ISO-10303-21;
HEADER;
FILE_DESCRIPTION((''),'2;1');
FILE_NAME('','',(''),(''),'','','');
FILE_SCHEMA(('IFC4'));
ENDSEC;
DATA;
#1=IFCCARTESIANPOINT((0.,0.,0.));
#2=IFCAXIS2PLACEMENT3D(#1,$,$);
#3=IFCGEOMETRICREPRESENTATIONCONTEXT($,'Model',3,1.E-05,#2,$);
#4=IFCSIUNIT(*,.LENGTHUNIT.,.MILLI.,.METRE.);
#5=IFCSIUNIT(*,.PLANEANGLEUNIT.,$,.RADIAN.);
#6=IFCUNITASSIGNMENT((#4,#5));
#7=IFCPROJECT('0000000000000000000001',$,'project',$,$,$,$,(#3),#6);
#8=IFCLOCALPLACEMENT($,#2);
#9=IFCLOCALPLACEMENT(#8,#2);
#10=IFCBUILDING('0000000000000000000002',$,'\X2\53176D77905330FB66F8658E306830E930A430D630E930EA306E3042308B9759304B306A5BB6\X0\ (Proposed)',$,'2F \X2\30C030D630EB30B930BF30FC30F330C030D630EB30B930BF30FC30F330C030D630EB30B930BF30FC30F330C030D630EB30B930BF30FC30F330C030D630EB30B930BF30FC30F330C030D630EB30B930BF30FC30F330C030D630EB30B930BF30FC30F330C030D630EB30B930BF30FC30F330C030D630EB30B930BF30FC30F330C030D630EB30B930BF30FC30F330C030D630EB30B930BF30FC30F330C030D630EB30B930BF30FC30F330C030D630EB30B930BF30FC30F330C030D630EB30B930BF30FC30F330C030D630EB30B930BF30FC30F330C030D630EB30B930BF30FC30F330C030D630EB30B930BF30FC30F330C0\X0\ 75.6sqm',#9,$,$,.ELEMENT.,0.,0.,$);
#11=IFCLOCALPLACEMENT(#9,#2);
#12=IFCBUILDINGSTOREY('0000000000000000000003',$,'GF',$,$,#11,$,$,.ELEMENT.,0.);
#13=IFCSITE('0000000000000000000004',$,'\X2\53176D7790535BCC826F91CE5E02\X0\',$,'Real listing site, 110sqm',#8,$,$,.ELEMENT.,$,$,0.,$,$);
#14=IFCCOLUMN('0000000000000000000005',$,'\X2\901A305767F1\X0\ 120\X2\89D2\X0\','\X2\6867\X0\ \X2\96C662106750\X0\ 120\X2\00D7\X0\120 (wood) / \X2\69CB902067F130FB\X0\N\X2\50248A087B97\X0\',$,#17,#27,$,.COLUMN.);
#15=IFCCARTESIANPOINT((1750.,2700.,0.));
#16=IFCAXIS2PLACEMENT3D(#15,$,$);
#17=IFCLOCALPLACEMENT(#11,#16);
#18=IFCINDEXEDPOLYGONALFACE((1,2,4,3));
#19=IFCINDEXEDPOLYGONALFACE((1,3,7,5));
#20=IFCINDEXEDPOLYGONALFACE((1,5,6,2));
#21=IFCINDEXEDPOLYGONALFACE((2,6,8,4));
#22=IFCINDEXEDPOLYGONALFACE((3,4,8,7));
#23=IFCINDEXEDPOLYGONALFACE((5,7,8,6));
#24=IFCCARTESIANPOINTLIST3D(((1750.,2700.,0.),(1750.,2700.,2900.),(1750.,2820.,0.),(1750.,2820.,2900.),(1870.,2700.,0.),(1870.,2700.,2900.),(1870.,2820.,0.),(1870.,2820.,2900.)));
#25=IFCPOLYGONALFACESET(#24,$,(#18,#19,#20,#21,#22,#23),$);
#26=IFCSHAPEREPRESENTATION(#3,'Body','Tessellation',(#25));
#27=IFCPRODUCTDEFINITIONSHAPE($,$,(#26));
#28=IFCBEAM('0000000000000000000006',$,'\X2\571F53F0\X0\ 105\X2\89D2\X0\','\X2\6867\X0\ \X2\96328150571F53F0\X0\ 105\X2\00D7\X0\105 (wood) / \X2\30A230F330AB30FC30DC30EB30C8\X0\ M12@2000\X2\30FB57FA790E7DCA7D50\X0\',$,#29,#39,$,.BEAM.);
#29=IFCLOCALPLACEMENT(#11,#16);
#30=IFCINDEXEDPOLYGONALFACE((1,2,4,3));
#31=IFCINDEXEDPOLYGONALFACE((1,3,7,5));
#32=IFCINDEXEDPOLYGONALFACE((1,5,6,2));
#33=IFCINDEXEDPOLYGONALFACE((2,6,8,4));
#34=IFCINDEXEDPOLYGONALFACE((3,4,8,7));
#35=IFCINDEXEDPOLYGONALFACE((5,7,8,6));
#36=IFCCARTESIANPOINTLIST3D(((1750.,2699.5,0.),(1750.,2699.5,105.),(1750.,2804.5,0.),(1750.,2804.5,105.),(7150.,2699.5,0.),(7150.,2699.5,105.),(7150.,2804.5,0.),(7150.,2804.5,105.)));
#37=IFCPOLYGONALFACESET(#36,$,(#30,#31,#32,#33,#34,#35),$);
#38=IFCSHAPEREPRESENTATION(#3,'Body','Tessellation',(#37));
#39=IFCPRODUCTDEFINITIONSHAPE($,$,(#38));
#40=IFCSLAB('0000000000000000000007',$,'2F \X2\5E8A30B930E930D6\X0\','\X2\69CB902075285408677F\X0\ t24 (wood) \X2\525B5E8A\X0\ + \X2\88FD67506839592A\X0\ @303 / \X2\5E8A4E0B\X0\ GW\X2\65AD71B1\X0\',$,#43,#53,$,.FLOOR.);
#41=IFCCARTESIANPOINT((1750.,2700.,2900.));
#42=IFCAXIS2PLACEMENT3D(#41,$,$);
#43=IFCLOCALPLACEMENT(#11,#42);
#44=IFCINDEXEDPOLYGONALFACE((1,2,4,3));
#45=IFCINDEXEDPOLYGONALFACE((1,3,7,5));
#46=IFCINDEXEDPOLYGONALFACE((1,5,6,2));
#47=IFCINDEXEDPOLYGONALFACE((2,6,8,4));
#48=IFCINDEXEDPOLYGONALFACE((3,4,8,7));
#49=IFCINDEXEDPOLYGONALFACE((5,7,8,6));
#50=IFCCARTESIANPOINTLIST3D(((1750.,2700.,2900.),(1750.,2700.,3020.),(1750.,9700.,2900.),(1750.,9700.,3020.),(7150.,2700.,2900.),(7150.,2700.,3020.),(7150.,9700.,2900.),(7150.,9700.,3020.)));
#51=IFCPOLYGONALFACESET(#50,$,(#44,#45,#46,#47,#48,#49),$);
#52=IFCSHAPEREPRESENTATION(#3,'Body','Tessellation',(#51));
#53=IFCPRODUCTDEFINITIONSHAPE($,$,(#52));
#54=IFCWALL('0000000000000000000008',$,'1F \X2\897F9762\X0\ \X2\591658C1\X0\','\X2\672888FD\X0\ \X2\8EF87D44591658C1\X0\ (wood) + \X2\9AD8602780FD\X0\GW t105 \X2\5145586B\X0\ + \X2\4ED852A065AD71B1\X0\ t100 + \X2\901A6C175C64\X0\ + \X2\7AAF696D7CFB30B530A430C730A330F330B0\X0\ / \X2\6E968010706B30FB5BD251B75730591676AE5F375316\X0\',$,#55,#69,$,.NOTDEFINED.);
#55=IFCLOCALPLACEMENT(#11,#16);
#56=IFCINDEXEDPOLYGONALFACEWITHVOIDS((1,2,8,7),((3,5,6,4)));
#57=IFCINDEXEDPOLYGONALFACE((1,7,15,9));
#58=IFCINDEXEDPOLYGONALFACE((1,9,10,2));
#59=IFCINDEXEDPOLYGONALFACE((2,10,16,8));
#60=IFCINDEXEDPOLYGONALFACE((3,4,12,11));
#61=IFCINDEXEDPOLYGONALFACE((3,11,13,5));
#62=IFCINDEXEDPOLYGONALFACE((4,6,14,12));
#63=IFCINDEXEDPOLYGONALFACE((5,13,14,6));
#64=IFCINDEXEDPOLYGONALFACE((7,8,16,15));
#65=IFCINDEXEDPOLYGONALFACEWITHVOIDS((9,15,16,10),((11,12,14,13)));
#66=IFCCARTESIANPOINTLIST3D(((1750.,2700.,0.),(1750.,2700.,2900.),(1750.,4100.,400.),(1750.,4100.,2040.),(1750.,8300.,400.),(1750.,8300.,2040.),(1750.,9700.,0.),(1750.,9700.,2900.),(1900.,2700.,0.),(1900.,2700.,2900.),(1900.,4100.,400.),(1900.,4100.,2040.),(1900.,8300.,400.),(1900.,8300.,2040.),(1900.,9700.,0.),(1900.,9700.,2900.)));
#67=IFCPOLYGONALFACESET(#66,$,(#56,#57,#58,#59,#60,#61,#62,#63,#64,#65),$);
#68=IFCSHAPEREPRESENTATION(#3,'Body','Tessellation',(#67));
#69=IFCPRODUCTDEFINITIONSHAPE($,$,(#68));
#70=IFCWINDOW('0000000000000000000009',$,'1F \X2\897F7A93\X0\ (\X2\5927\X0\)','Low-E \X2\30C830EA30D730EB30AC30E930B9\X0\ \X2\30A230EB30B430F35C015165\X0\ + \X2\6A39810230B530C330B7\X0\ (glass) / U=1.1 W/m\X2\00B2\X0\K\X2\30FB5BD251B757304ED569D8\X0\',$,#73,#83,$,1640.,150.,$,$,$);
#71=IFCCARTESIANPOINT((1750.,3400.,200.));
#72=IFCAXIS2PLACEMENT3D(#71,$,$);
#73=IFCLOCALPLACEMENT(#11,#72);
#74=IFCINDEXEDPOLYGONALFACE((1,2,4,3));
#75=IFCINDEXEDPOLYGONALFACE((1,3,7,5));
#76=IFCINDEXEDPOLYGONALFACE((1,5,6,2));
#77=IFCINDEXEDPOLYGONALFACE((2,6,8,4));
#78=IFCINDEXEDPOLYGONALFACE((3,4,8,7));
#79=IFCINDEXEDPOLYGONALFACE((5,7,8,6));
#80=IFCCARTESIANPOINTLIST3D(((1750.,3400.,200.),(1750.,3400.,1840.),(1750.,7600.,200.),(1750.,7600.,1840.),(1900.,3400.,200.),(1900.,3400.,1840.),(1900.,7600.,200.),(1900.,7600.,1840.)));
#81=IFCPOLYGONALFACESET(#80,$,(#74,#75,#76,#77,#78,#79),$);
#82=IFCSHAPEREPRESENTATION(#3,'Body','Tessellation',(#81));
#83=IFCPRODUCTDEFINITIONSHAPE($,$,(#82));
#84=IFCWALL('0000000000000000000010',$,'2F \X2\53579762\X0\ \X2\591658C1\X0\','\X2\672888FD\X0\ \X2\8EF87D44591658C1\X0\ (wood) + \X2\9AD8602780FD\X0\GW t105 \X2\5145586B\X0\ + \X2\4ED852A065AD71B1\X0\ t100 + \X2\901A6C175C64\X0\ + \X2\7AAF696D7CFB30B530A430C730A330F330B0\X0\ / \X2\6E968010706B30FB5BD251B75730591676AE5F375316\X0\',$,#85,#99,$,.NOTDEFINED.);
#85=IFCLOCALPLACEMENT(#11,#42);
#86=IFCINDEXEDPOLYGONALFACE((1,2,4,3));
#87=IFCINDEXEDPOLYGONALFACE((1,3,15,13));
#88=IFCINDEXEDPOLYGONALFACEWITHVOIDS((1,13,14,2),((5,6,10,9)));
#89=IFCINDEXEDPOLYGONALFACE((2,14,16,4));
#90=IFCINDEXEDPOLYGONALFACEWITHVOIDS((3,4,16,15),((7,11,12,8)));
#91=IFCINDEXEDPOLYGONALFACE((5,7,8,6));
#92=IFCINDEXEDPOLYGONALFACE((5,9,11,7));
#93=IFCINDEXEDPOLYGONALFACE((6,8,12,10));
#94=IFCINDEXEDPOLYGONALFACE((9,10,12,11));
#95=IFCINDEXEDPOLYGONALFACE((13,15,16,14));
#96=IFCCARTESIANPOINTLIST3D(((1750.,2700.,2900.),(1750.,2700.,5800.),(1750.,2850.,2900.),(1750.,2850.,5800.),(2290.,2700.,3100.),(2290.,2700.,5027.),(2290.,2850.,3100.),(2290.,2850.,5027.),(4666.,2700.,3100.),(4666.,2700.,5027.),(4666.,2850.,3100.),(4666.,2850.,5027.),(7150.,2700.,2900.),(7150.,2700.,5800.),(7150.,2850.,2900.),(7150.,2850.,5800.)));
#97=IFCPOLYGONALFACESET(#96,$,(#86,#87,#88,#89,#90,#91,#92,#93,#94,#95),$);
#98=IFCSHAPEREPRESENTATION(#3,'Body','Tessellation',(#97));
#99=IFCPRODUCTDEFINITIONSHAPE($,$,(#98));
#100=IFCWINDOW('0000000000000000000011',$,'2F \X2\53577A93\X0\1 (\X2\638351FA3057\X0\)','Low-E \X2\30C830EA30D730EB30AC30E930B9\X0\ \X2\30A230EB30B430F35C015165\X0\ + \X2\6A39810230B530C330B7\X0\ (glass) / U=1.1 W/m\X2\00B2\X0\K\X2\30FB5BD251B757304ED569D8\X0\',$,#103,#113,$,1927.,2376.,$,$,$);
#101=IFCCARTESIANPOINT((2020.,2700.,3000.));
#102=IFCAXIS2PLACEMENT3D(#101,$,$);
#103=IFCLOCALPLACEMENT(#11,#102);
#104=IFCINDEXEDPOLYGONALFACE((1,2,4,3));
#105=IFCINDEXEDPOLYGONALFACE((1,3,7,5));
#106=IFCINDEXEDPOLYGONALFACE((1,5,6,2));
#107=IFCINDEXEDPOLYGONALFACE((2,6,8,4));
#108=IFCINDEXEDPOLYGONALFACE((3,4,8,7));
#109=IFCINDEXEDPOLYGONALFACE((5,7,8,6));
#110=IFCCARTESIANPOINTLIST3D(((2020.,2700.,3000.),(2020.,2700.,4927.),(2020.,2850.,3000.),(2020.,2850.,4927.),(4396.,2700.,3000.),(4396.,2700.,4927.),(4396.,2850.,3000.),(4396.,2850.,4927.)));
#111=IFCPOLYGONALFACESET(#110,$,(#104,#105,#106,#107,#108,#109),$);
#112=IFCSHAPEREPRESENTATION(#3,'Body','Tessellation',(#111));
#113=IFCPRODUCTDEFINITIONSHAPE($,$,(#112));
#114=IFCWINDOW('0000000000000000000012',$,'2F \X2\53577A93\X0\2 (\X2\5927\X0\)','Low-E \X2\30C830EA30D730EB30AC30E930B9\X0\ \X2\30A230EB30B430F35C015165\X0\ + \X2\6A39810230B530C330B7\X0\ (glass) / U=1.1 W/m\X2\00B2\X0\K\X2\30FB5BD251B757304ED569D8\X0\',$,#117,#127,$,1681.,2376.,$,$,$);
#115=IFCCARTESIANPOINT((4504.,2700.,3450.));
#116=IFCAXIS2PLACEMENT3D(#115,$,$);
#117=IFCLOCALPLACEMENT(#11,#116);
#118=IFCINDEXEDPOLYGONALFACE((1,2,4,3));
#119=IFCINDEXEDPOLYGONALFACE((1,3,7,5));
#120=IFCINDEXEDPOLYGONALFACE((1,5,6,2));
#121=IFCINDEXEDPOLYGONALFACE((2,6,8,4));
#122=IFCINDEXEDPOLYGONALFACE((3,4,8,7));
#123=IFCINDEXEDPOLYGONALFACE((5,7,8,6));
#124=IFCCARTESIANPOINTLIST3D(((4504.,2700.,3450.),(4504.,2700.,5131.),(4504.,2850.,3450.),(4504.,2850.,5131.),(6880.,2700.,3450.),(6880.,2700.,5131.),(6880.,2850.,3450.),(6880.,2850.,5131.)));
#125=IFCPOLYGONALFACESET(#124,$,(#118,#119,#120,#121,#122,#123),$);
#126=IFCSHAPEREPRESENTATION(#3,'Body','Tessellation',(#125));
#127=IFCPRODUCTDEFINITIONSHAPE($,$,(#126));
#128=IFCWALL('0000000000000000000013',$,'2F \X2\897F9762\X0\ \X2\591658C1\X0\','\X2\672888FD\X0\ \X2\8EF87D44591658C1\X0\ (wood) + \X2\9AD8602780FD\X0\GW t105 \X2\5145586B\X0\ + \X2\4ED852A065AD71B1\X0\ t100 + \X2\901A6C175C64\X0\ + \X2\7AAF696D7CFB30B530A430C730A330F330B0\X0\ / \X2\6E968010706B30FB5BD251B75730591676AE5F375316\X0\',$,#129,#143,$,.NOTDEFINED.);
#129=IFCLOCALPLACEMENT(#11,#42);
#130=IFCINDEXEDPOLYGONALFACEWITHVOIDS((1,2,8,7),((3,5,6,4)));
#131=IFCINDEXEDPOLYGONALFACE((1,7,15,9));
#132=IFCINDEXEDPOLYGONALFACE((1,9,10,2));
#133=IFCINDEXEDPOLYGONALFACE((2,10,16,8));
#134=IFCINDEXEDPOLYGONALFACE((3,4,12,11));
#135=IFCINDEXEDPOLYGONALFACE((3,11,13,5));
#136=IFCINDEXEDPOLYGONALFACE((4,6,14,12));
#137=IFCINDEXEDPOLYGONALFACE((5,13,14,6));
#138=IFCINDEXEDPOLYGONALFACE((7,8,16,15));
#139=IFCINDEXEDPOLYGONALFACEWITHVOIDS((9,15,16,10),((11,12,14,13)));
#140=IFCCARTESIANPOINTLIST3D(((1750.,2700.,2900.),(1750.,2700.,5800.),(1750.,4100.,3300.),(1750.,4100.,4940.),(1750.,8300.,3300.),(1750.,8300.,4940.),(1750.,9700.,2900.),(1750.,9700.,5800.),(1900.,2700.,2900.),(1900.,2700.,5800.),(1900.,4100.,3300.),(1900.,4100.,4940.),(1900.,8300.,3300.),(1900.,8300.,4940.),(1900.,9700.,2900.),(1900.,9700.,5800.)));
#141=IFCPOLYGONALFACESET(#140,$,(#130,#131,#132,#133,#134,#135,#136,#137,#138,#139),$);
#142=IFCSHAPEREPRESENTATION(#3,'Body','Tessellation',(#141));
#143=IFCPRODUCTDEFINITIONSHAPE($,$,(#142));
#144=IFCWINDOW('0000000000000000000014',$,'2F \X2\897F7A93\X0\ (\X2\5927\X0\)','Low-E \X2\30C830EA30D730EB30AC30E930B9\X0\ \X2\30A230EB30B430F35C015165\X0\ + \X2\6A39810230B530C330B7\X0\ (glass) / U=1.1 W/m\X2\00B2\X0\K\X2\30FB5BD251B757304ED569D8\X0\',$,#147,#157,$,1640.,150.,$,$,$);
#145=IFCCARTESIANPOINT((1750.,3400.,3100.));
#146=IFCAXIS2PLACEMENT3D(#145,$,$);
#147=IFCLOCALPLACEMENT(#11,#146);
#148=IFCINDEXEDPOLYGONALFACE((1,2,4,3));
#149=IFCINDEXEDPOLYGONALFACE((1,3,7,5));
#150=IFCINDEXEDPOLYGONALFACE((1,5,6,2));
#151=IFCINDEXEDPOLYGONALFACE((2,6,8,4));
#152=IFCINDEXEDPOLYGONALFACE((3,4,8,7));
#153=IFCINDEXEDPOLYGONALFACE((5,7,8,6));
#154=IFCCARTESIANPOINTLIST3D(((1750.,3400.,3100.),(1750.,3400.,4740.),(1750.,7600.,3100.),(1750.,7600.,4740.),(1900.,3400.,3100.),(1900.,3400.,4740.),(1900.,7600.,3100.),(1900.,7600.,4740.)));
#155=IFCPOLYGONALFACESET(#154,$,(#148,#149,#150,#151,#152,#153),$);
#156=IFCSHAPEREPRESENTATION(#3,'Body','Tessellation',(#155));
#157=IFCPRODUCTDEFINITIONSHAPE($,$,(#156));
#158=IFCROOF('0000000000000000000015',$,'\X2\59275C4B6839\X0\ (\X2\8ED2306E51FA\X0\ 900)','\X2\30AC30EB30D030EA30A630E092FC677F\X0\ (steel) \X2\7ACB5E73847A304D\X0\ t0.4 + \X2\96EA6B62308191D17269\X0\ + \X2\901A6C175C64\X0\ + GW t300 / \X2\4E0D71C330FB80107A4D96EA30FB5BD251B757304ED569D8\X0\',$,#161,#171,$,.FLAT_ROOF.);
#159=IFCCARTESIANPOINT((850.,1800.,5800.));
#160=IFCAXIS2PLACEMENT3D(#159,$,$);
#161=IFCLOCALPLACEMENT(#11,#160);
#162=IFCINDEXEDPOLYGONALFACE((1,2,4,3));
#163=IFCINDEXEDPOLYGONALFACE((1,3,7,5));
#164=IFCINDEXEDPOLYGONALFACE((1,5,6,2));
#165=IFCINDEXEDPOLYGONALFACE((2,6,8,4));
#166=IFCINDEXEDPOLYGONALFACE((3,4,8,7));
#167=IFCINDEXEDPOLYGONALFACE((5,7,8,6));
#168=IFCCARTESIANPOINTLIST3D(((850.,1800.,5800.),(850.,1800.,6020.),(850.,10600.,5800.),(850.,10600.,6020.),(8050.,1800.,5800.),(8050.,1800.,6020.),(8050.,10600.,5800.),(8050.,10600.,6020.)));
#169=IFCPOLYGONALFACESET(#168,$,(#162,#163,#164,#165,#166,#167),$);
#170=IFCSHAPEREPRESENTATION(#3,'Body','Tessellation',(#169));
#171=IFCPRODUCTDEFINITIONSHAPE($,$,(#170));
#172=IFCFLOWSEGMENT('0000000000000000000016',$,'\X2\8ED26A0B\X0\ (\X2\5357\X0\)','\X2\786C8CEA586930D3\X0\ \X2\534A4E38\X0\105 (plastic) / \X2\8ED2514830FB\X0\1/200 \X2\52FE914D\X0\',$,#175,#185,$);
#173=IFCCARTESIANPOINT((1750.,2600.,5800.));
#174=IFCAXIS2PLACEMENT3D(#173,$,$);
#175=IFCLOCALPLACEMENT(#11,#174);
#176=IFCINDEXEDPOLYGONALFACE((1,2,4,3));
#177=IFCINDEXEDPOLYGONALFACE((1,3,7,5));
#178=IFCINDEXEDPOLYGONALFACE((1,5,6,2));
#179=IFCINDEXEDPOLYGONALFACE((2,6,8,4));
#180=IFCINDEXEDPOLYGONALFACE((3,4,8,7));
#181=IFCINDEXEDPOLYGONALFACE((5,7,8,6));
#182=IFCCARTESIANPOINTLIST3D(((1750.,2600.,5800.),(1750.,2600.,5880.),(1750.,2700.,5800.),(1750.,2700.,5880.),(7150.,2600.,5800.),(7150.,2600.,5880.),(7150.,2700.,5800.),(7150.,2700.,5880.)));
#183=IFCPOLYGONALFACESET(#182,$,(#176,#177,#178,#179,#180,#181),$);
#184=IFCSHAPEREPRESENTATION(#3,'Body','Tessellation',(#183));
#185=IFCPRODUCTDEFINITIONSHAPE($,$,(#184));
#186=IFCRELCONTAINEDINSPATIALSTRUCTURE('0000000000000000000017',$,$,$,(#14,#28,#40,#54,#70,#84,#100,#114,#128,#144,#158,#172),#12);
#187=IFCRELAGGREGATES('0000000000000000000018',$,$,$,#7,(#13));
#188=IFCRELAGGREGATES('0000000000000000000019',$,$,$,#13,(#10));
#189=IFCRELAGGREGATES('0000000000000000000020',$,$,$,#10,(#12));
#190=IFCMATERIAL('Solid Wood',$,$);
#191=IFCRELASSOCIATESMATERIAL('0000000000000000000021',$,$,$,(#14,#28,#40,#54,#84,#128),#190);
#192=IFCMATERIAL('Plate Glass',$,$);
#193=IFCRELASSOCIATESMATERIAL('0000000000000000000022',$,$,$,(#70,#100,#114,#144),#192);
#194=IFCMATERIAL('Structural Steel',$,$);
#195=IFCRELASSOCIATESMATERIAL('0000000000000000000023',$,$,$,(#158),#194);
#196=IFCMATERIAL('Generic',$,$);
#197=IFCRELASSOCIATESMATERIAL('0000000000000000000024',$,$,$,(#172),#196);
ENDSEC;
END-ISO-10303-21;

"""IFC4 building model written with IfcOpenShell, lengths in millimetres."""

from ifc_helpers import new_model, si_unit, frame, frame_2d, origin, place, context, project, spatial, rectangle, extrude, material, element, fill, save


model = new_model("IFC4")

# Units and contexts
model_context = context("Model", 3, precision=1e-05, world=origin())
ifc_project = project(units=[si_unit("LENGTHUNIT", "METRE", prefix="MILLI"), si_unit("PLANEANGLEUNIT", "RADIAN")], contexts=[model_context])

# Site, building, storey
site_placement = place(None, origin())
site = spatial("IfcSite", under=ifc_project, at=site_placement, Name="北海道富良野市", ObjectType="Real listing site, 110sqm", CompositionType="ELEMENT", RefElevation=0.0)
building_placement = place(site_placement, origin())
building = spatial("IfcBuilding", under=site, at=building_placement, Name="北海道・書斎とライブラリのある静かな家 (Proposed)", ObjectType="2F ダブルスターンダブルスターンダブルスターンダブルスターンダブルスターンダブルスターンダブルスターンダブルスターンダブルスターンダブルスターンダブルスターンダブルスターンダブルスターンダブルスターンダブルスターンダブルスターンダブルスターンダ 75.6sqm", CompositionType="ELEMENT", ElevationOfRefHeight=0.0, ElevationOfTerrain=0.0)
storey_placement = place(building_placement, origin())
storey = spatial("IfcBuildingStorey", under=building, at=storey_placement, Name="GF", CompositionType="ELEMENT", Elevation=0.0)

# Column
ifc_material_1 = material(Name="Solid Wood")
column_placement = place(storey_placement, frame((1750.0, 2700.0, 0.0)))
element("IfcColumn", 1, at=column_placement, inside=storey, material=ifc_material_1, Name="通し柱 120角", Description="桧 集成材 120×120 (wood) / 構造柱・N値計算", PredefinedType="COLUMN", context=model_context, shape_type="SweptSolid", body=[
    extrude(rectangle(XDim=120.0, YDim=120.0, at=frame_2d((60.0, 60.0))), frame((1750.0, 2700.0, 0.0)), (0.0, 0.0, 1.0), 2900.0),
])

# Beam
beam_1_placement = place(storey_placement, frame((1750.0, 2700.0, 0.0)))
element("IfcBeam", 2, at=beam_1_placement, inside=storey, material=ifc_material_1, Name="土台 105角", Description="桧 防腐土台 105×105 (wood) / アンカーボルト M12@2000・基礎緊結", PredefinedType="BEAM", context=model_context, shape_type="SweptSolid", body=[
    extrude(rectangle(XDim=5400.0, YDim=105.0, at=frame_2d((2700.0, 52.0))), frame((1750.0, 2700.0, 0.0)), (0.0, 0.0, 1.0), 105.0),
])

# Slab
slab_1_placement = place(storey_placement, frame((1750.0, 2700.0, 2900.0)))
element("IfcSlab", 3, at=slab_1_placement, inside=storey, material=ifc_material_1, Name="2F 床スラブ", Description="構造用合板 t24 (wood) 剛床 + 製材根太 @303 / 床下 GW断熱", PredefinedType="FLOOR", context=model_context, shape_type="SweptSolid", body=[
    extrude(rectangle(XDim=5400.0, YDim=7000.0, at=frame_2d((2700.0, 3500.0))), frame((1750.0, 2700.0, 2900.0)), (0.0, 0.0, 1.0), 120.0),
])

# Shared definitions
ifc_material_2 = material(Name="Plate Glass")

# Wall, opening, window
wall_1_placement = place(storey_placement, frame((1750.0, 2700.0, 0.0)))
wall_1 = element("IfcWall", 4, at=wall_1_placement, inside=storey, material=ifc_material_1, Name="1F 西面 外壁", Description="木製 軸組外壁 (wood) + 高性能GW t105 充填 + 付加断熱 t100 + 通気層 + 窯業系サイディング / 準耐火・寒冷地外皮強化", PredefinedType="NOTDEFINED", context=model_context, shape_type="SweptSolid", body=[
    extrude(rectangle(XDim=150.0, YDim=7000.0, at=frame_2d((75.0, 3500.0))), frame((1750.0, 2700.0, 0.0)), (0.0, 0.0, 1.0), 2900.0),
])
opening_1_placement = place(storey_placement, frame((1750.0, 3400.0, 200.0)))
opening_1 = element("IfcOpeningElement", 5, at=opening_1_placement, cuts=wall_1, PredefinedType="NOTDEFINED", context=model_context, shape_type="SweptSolid", body=[
    extrude(rectangle(XDim=150.0, YDim=4200.0, at=frame_2d((75.0, 2100.0))), frame((1750.0, 3400.0, 200.0)), (0.0, 0.0, 1.0), 1640.0),
])
window_1_placement = place(storey_placement, frame((1750.0, 3400.0, 200.0)))
window_1 = element("IfcWindow", 6, at=window_1_placement, inside=storey, material=ifc_material_2, Name="1F 西窓 (大)", Description="Low-E トリプルガラス アルゴン封入 + 樹脂サッシ (glass) / U=1.1 W/m²K・寒冷地仕様", OverallHeight=1640.0, OverallWidth=150.0, context=model_context, shape_type="SweptSolid", body=[
    extrude(rectangle(XDim=150.0, YDim=4200.0, at=frame_2d((75.0, 2100.0))), frame((1750.0, 3400.0, 200.0)), (0.0, 0.0, 1.0), 1640.0),
])
fill(opening_1, window_1)

# Wall, openings, windows
wall_2_placement = place(storey_placement, frame((1750.0, 2700.0, 2900.0)))
wall_2 = element("IfcWall", 7, at=wall_2_placement, inside=storey, material=ifc_material_1, Name="2F 南面 外壁", Description="木製 軸組外壁 (wood) + 高性能GW t105 充填 + 付加断熱 t100 + 通気層 + 窯業系サイディング / 準耐火・寒冷地外皮強化", PredefinedType="NOTDEFINED", context=model_context, shape_type="SweptSolid", body=[
    extrude(rectangle(XDim=5400.0, YDim=150.0, at=frame_2d((2700.0, 75.0))), frame((1750.0, 2700.0, 2900.0)), (0.0, 0.0, 1.0), 2900.0),
])
opening_2_placement = place(storey_placement, frame((2020.0, 2700.0, 3000.0)))
opening_2 = element("IfcOpeningElement", 8, at=opening_2_placement, cuts=wall_2, PredefinedType="NOTDEFINED", context=model_context, shape_type="SweptSolid", body=[
    extrude(rectangle(XDim=2376.0, YDim=150.0, at=frame_2d((1188.0, 75.0))), frame((2020.0, 2700.0, 3000.0)), (0.0, 0.0, 1.0), 1927.0),
])
opening_3_placement = place(storey_placement, frame((4504.0, 2700.0, 3450.0)))
opening_3 = element("IfcOpeningElement", 9, at=opening_3_placement, cuts=wall_2, PredefinedType="NOTDEFINED", context=model_context, shape_type="SweptSolid", body=[
    extrude(rectangle(XDim=2376.0, YDim=150.0, at=frame_2d((1188.0, 75.0))), frame((4504.0, 2700.0, 3450.0)), (0.0, 0.0, 1.0), 1681.0),
])
window_2_placement = place(storey_placement, frame((2020.0, 2700.0, 3000.0)))
window_2 = element("IfcWindow", 10, at=window_2_placement, inside=storey, material=ifc_material_2, Name="2F 南窓1 (掃出し)", Description="Low-E トリプルガラス アルゴン封入 + 樹脂サッシ (glass) / U=1.1 W/m²K・寒冷地仕様", OverallHeight=1927.0, OverallWidth=2376.0, context=model_context, shape_type="SweptSolid", body=[
    extrude(rectangle(XDim=2376.0, YDim=150.0, at=frame_2d((1188.0, 75.0))), frame((2020.0, 2700.0, 3000.0)), (0.0, 0.0, 1.0), 1927.0),
])
fill(opening_2, window_2)
window_3_placement = place(storey_placement, frame((4504.0, 2700.0, 3450.0)))
window_3 = element("IfcWindow", 11, at=window_3_placement, inside=storey, material=ifc_material_2, Name="2F 南窓2 (大)", Description="Low-E トリプルガラス アルゴン封入 + 樹脂サッシ (glass) / U=1.1 W/m²K・寒冷地仕様", OverallHeight=1681.0, OverallWidth=2376.0, context=model_context, shape_type="SweptSolid", body=[
    extrude(rectangle(XDim=2376.0, YDim=150.0, at=frame_2d((1188.0, 75.0))), frame((4504.0, 2700.0, 3450.0)), (0.0, 0.0, 1.0), 1681.0),
])
fill(opening_3, window_3)

# Wall, opening, window
wall_3_placement = place(storey_placement, frame((1750.0, 2700.0, 2900.0)))
wall_3 = element("IfcWall", 12, at=wall_3_placement, inside=storey, material=ifc_material_1, Name="2F 西面 外壁", Description="木製 軸組外壁 (wood) + 高性能GW t105 充填 + 付加断熱 t100 + 通気層 + 窯業系サイディング / 準耐火・寒冷地外皮強化", PredefinedType="NOTDEFINED", context=model_context, shape_type="SweptSolid", body=[
    extrude(rectangle(XDim=150.0, YDim=7000.0, at=frame_2d((75.0, 3500.0))), frame((1750.0, 2700.0, 2900.0)), (0.0, 0.0, 1.0), 2900.0),
])
opening_4_placement = place(storey_placement, frame((1750.0, 3400.0, 3100.0)))
opening_4 = element("IfcOpeningElement", 13, at=opening_4_placement, cuts=wall_3, PredefinedType="NOTDEFINED", context=model_context, shape_type="SweptSolid", body=[
    extrude(rectangle(XDim=150.0, YDim=4200.0, at=frame_2d((75.0, 2100.0))), frame((1750.0, 3400.0, 3100.0)), (0.0, 0.0, 1.0), 1640.0),
])
window_4_placement = place(storey_placement, frame((1750.0, 3400.0, 3100.0)))
window_4 = element("IfcWindow", 14, at=window_4_placement, inside=storey, material=ifc_material_2, Name="2F 西窓 (大)", Description="Low-E トリプルガラス アルゴン封入 + 樹脂サッシ (glass) / U=1.1 W/m²K・寒冷地仕様", OverallHeight=1640.0, OverallWidth=150.0, context=model_context, shape_type="SweptSolid", body=[
    extrude(rectangle(XDim=150.0, YDim=4200.0, at=frame_2d((75.0, 2100.0))), frame((1750.0, 3400.0, 3100.0)), (0.0, 0.0, 1.0), 1640.0),
])
fill(opening_4, window_4)

# Roof
ifc_material_3 = material(Name="Structural Steel")
roof_placement = place(storey_placement, frame((850.0, 1800.0, 5800.0)))
element("IfcRoof", 15, at=roof_placement, inside=storey, material=ifc_material_3, Name="大屋根 (軒の出 900)", Description="ガルバリウム鋼板 (steel) 立平葺き t0.4 + 雪止め金物 + 通気層 + GW t300 / 不燃・耐積雪・寒冷地仕様", PredefinedType="FLAT_ROOF", context=model_context, shape_type="SweptSolid", body=[
    extrude(rectangle(XDim=7200.0, YDim=8800.0, at=frame_2d((3600.0, 4400.0))), frame((850.0, 1800.0, 5800.0)), (0.0, 0.0, 1.0), 220.0),
])

# Flow segment
ifc_material_4 = material(Name="Generic")
flow_segment_1_placement = place(storey_placement, frame((1750.0, 2600.0, 5800.0)))
element("IfcFlowSegment", 16, at=flow_segment_1_placement, inside=storey, material=ifc_material_4, Name="軒樋 (南)", Description="硬質塩ビ 半丸105 (plastic) / 軒先・1/200 勾配", context=model_context, shape_type="SweptSolid", body=[
    extrude(rectangle(XDim=5400.0, YDim=100.0, at=frame_2d((2700.0, 50.0))), frame((1750.0, 2600.0, 5800.0)), (0.0, 0.0, 1.0), 80.0),
])

save(model, "model.ifc")
